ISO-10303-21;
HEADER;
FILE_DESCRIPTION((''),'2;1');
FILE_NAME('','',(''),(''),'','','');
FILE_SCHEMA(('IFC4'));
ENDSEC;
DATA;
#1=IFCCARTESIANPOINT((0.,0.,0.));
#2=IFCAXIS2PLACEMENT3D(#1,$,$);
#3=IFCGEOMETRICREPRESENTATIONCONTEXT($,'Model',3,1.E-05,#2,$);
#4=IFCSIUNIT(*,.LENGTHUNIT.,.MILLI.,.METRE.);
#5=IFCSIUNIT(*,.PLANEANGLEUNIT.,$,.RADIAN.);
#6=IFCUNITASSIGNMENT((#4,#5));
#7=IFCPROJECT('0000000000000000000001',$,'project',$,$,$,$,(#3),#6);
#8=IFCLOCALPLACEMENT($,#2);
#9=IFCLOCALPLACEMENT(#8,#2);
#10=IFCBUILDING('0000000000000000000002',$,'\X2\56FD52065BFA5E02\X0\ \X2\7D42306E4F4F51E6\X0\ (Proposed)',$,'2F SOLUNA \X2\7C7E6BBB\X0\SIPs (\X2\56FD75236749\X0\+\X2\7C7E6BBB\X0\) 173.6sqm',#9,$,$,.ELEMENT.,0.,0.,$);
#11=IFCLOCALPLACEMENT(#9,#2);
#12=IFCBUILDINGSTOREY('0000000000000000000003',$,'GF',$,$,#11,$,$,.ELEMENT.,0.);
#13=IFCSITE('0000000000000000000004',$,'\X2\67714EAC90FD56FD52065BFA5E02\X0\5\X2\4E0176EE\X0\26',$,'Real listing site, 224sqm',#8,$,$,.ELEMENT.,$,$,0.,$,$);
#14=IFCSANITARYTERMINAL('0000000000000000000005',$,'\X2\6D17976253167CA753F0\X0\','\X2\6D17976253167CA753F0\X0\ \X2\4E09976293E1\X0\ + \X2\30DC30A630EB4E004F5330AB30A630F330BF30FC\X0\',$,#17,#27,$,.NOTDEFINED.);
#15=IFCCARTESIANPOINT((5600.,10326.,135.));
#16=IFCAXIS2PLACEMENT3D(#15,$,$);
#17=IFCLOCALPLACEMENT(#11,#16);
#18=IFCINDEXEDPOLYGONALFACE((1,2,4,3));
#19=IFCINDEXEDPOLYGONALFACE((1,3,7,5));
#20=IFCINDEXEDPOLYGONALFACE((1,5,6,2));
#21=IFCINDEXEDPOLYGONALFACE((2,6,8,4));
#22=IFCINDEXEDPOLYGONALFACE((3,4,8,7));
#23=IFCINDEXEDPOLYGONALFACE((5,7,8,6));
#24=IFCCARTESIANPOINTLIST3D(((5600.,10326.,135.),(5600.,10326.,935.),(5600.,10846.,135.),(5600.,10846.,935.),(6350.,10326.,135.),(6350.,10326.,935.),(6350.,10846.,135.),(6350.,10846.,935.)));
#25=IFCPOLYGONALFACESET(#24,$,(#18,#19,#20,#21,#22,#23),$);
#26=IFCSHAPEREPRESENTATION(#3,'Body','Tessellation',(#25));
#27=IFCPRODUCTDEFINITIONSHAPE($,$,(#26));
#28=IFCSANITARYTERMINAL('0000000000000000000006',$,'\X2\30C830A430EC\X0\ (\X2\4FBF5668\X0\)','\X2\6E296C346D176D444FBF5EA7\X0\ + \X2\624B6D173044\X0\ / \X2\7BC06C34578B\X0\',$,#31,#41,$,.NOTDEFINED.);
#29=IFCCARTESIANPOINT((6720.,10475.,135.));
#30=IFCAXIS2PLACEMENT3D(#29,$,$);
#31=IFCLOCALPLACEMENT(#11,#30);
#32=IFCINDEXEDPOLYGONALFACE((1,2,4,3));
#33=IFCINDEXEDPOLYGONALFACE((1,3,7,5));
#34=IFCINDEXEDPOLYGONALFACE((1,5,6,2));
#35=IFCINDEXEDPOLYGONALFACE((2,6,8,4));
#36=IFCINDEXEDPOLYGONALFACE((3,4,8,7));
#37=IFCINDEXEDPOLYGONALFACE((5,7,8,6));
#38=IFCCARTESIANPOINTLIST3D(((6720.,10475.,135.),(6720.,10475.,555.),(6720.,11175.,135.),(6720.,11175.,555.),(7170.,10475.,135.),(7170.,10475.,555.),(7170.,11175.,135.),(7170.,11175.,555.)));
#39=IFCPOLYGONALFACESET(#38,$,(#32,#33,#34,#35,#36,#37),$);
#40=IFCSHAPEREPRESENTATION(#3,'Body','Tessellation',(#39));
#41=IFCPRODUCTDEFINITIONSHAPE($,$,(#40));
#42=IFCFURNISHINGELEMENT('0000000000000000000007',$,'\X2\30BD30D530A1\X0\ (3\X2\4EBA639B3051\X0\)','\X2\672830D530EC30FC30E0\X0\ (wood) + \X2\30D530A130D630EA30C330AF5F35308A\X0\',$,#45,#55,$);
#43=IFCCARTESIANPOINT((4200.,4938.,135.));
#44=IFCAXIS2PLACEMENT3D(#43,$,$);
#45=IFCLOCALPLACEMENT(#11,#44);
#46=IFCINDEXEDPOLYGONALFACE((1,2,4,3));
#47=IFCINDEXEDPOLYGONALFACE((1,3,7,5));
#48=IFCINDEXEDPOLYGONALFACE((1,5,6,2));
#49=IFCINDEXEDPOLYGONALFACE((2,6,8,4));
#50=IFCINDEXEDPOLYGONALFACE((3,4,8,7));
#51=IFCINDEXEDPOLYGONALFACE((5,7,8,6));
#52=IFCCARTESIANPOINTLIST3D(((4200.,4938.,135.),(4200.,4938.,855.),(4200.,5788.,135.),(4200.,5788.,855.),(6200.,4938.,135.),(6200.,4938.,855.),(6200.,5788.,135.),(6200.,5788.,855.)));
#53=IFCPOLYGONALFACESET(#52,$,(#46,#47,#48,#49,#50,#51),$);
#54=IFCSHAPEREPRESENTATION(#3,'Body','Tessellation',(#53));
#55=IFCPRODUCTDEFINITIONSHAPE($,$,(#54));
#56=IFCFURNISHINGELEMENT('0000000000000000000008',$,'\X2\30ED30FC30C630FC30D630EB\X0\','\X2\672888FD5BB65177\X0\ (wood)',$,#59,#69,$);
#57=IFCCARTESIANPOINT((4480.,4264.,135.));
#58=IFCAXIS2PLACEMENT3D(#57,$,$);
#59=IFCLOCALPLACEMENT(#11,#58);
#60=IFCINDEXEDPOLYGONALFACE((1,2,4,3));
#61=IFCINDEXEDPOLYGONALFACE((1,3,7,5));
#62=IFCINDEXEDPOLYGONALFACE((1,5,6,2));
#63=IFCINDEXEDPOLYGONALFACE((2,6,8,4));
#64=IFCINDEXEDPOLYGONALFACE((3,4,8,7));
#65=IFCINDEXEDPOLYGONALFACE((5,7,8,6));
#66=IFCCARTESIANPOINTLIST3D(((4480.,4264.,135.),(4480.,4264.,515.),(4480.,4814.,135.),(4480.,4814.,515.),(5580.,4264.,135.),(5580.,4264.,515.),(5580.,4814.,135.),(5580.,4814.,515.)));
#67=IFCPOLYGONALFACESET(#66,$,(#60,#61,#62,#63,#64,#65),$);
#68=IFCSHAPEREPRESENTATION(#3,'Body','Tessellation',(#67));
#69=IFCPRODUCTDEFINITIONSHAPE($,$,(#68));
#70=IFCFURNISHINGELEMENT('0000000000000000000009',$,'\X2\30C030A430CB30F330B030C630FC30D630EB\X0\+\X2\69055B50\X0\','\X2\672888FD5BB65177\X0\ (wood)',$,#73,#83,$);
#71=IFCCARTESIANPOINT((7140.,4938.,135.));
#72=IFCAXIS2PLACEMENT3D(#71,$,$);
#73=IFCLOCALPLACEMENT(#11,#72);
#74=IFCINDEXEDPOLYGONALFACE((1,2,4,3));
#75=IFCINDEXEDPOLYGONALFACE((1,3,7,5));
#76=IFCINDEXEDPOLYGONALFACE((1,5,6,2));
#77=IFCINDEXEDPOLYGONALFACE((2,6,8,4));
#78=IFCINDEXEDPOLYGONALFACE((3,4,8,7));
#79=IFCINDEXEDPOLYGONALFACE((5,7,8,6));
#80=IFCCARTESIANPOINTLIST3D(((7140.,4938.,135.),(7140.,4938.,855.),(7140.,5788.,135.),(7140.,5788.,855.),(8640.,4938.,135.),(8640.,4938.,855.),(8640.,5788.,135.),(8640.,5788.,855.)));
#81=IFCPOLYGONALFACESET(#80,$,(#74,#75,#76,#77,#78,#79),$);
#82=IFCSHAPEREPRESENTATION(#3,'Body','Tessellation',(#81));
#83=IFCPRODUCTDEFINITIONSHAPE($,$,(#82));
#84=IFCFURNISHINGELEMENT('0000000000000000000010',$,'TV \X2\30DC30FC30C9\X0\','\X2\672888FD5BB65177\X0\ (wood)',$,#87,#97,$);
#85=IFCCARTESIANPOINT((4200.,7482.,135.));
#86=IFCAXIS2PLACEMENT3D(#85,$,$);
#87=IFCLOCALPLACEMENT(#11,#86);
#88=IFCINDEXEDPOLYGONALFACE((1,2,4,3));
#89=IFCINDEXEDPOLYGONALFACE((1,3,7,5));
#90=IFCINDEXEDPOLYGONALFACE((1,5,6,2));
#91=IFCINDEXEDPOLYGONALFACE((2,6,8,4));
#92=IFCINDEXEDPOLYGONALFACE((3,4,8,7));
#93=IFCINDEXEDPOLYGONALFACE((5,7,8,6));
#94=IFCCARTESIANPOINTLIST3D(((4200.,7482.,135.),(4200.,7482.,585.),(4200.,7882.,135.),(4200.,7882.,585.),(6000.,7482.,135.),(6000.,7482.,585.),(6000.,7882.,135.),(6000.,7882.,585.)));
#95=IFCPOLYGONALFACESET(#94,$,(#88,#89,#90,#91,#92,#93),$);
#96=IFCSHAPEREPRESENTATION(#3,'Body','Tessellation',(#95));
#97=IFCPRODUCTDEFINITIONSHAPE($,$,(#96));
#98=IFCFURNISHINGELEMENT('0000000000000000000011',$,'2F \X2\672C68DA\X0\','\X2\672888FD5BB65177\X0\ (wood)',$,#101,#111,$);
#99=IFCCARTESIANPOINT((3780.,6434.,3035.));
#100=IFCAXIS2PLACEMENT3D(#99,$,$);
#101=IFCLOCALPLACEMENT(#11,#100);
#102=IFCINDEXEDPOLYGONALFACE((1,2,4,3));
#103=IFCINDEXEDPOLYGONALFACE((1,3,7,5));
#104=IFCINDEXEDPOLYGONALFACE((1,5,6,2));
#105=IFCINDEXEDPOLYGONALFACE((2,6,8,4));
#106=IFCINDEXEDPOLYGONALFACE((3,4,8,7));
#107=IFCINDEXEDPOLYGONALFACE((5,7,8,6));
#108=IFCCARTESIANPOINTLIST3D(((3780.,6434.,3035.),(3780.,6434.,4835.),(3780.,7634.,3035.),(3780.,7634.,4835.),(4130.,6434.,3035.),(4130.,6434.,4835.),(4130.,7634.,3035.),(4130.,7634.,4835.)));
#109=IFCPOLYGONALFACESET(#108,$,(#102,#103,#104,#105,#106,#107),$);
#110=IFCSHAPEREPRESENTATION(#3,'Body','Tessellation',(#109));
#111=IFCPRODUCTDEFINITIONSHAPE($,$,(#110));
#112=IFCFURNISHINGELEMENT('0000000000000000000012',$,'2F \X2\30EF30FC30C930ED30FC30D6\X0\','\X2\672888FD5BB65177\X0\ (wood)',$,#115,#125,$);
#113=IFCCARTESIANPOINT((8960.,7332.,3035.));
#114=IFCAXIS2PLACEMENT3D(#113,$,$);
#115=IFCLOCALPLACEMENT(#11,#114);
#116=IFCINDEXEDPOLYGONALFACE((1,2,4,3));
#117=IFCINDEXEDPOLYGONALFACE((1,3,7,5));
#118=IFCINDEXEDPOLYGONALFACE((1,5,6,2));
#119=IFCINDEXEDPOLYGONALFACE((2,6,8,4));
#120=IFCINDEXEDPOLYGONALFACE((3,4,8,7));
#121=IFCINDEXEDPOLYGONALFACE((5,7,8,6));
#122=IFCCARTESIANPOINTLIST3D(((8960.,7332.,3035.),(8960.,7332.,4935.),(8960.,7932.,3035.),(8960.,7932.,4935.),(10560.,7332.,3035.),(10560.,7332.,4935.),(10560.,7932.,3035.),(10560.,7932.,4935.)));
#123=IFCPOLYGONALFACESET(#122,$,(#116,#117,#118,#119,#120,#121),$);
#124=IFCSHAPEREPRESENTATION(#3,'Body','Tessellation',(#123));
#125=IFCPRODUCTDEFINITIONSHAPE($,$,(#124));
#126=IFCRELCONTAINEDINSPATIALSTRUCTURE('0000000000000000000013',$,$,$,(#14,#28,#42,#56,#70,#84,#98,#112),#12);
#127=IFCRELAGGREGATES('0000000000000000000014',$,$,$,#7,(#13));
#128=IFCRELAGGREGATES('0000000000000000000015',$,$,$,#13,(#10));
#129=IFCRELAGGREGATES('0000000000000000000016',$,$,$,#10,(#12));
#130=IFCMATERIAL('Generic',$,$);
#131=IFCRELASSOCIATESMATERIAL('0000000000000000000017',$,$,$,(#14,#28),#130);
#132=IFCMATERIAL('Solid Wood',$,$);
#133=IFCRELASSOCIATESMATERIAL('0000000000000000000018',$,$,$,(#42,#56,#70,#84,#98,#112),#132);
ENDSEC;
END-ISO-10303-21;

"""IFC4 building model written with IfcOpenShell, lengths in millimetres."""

from ifc_helpers import new_model, si_unit, frame, frame_2d, origin, place, context, project, spatial, rectangle, extrude, material, element, save


model = new_model("IFC4")

# Units and contexts
model_context = context("Model", 3, precision=1e-05, world=origin())
ifc_project = project(units=[si_unit("LENGTHUNIT", "METRE", prefix="MILLI"), si_unit("PLANEANGLEUNIT", "RADIAN")], contexts=[model_context])

# Site, building, storey
site_placement = place(None, origin())
site = spatial("IfcSite", under=ifc_project, at=site_placement, Name="東京都国分寺市5丁目26", ObjectType="Real listing site, 224sqm", CompositionType="ELEMENT", RefElevation=0.0)
building_placement = place(site_placement, origin())
building = spatial("IfcBuilding", under=site, at=building_placement, Name="国分寺市 終の住処 (Proposed)", ObjectType="2F SOLUNA 籾殻SIPs (国産杉+籾殻) 173.6sqm", CompositionType="ELEMENT", ElevationOfRefHeight=0.0, ElevationOfTerrain=0.0)
storey_placement = place(building_placement, origin())
storey = spatial("IfcBuildingStorey", under=building, at=storey_placement, Name="GF", CompositionType="ELEMENT", Elevation=0.0)

# Shared definitions
ifc_material_1 = material(Name="Generic")

# Shared definitions
ifc_material_2 = material(Name="Solid Wood")

# Sanitary terminals
sanitary_terminal_1_placement = place(storey_placement, frame((5600.0, 10326.0, 135.0)))
element("IfcSanitaryTerminal", 1, at=sanitary_terminal_1_placement, inside=storey, material=ifc_material_1, Name="洗面化粧台", Description="洗面化粧台 三面鏡 + ボウル一体カウンター", PredefinedType="NOTDEFINED", context=model_context, shape_type="SweptSolid", body=[
    extrude(rectangle(XDim=750.0, YDim=520.0, at=frame_2d((375.0, 260.0))), frame((5600.0, 10326.0, 135.0)), (0.0, 0.0, 1.0), 800.0),
])
sanitary_terminal_2_placement = place(storey_placement, frame((6720.0, 10475.0, 135.0)))
element("IfcSanitaryTerminal", 2, at=sanitary_terminal_2_placement, inside=storey, material=ifc_material_1, Name="トイレ (便器)", Description="温水洗浄便座 + 手洗い / 節水型", PredefinedType="NOTDEFINED", context=model_context, shape_type="SweptSolid", body=[
    extrude(rectangle(XDim=450.0, YDim=700.0, at=frame_2d((225.0, 350.0))), frame((6720.0, 10475.0, 135.0)), (0.0, 0.0, 1.0), 420.0),
])

# Furnishing elements
furnishing_1_placement = place(storey_placement, frame((4200.0, 4938.0, 135.0)))
element("IfcFurnishingElement", 3, at=furnishing_1_placement, inside=storey, material=ifc_material_2, Name="ソファ (3人掛け)", Description="木フレーム (wood) + ファブリック張り", context=model_context, shape_type="SweptSolid", body=[
    extrude(rectangle(XDim=2000.0, YDim=850.0, at=frame_2d((1000.0, 425.0))), frame((4200.0, 4938.0, 135.0)), (0.0, 0.0, 1.0), 720.0),
])
furnishing_2_placement = place(storey_placement, frame((4480.0, 4264.0, 135.0)))
element("IfcFurnishingElement", 4, at=furnishing_2_placement, inside=storey, material=ifc_material_2, Name="ローテーブル", Description="木製家具 (wood)", context=model_context, shape_type="SweptSolid", body=[
    extrude(rectangle(XDim=1100.0, YDim=550.0, at=frame_2d((550.0, 275.0))), frame((4480.0, 4264.0, 135.0)), (0.0, 0.0, 1.0), 380.0),
])
furnishing_3_placement = place(storey_placement, frame((7140.0, 4938.0, 135.0)))
element("IfcFurnishingElement", 5, at=furnishing_3_placement, inside=storey, material=ifc_material_2, Name="ダイニングテーブル+椅子", Description="木製家具 (wood)", context=model_context, shape_type="SweptSolid", body=[
    extrude(rectangle(XDim=1500.0, YDim=850.0, at=frame_2d((750.0, 425.0))), frame((7140.0, 4938.0, 135.0)), (0.0, 0.0, 1.0), 720.0),
])
furnishing_4_placement = place(storey_placement, frame((4200.0, 7482.0, 135.0)))
element("IfcFurnishingElement", 6, at=furnishing_4_placement, inside=storey, material=ifc_material_2, Name="TV ボード", Description="木製家具 (wood)", context=model_context, shape_type="SweptSolid", body=[
    extrude(rectangle(XDim=1800.0, YDim=400.0, at=frame_2d((900.0, 200.0))), frame((4200.0, 7482.0, 135.0)), (0.0, 0.0, 1.0), 450.0),
])
furnishing_5_placement = place(storey_placement, frame((3780.0, 6434.0, 3035.0)))
element("IfcFurnishingElement", 7, at=furnishing_5_placement, inside=storey, material=ifc_material_2, Name="2F 本棚", Description="木製家具 (wood)", context=model_context, shape_type="SweptSolid", body=[
    extrude(rectangle(XDim=350.0, YDim=1200.0, at=frame_2d((175.0, 600.0))), frame((3780.0, 6434.0, 3035.0)), (0.0, 0.0, 1.0), 1800.0),
])
furnishing_6_placement = place(storey_placement, frame((8960.0, 7332.0, 3035.0)))
element("IfcFurnishingElement", 8, at=furnishing_6_placement, inside=storey, material=ifc_material_2, Name="2F ワードローブ", Description="木製家具 (wood)", context=model_context, shape_type="SweptSolid", body=[
    extrude(rectangle(XDim=1600.0, YDim=600.0, at=frame_2d((800.0, 300.0))), frame((8960.0, 7332.0, 3035.0)), (0.0, 0.0, 1.0), 1900.0),
])

save(model, "model.ifc")
